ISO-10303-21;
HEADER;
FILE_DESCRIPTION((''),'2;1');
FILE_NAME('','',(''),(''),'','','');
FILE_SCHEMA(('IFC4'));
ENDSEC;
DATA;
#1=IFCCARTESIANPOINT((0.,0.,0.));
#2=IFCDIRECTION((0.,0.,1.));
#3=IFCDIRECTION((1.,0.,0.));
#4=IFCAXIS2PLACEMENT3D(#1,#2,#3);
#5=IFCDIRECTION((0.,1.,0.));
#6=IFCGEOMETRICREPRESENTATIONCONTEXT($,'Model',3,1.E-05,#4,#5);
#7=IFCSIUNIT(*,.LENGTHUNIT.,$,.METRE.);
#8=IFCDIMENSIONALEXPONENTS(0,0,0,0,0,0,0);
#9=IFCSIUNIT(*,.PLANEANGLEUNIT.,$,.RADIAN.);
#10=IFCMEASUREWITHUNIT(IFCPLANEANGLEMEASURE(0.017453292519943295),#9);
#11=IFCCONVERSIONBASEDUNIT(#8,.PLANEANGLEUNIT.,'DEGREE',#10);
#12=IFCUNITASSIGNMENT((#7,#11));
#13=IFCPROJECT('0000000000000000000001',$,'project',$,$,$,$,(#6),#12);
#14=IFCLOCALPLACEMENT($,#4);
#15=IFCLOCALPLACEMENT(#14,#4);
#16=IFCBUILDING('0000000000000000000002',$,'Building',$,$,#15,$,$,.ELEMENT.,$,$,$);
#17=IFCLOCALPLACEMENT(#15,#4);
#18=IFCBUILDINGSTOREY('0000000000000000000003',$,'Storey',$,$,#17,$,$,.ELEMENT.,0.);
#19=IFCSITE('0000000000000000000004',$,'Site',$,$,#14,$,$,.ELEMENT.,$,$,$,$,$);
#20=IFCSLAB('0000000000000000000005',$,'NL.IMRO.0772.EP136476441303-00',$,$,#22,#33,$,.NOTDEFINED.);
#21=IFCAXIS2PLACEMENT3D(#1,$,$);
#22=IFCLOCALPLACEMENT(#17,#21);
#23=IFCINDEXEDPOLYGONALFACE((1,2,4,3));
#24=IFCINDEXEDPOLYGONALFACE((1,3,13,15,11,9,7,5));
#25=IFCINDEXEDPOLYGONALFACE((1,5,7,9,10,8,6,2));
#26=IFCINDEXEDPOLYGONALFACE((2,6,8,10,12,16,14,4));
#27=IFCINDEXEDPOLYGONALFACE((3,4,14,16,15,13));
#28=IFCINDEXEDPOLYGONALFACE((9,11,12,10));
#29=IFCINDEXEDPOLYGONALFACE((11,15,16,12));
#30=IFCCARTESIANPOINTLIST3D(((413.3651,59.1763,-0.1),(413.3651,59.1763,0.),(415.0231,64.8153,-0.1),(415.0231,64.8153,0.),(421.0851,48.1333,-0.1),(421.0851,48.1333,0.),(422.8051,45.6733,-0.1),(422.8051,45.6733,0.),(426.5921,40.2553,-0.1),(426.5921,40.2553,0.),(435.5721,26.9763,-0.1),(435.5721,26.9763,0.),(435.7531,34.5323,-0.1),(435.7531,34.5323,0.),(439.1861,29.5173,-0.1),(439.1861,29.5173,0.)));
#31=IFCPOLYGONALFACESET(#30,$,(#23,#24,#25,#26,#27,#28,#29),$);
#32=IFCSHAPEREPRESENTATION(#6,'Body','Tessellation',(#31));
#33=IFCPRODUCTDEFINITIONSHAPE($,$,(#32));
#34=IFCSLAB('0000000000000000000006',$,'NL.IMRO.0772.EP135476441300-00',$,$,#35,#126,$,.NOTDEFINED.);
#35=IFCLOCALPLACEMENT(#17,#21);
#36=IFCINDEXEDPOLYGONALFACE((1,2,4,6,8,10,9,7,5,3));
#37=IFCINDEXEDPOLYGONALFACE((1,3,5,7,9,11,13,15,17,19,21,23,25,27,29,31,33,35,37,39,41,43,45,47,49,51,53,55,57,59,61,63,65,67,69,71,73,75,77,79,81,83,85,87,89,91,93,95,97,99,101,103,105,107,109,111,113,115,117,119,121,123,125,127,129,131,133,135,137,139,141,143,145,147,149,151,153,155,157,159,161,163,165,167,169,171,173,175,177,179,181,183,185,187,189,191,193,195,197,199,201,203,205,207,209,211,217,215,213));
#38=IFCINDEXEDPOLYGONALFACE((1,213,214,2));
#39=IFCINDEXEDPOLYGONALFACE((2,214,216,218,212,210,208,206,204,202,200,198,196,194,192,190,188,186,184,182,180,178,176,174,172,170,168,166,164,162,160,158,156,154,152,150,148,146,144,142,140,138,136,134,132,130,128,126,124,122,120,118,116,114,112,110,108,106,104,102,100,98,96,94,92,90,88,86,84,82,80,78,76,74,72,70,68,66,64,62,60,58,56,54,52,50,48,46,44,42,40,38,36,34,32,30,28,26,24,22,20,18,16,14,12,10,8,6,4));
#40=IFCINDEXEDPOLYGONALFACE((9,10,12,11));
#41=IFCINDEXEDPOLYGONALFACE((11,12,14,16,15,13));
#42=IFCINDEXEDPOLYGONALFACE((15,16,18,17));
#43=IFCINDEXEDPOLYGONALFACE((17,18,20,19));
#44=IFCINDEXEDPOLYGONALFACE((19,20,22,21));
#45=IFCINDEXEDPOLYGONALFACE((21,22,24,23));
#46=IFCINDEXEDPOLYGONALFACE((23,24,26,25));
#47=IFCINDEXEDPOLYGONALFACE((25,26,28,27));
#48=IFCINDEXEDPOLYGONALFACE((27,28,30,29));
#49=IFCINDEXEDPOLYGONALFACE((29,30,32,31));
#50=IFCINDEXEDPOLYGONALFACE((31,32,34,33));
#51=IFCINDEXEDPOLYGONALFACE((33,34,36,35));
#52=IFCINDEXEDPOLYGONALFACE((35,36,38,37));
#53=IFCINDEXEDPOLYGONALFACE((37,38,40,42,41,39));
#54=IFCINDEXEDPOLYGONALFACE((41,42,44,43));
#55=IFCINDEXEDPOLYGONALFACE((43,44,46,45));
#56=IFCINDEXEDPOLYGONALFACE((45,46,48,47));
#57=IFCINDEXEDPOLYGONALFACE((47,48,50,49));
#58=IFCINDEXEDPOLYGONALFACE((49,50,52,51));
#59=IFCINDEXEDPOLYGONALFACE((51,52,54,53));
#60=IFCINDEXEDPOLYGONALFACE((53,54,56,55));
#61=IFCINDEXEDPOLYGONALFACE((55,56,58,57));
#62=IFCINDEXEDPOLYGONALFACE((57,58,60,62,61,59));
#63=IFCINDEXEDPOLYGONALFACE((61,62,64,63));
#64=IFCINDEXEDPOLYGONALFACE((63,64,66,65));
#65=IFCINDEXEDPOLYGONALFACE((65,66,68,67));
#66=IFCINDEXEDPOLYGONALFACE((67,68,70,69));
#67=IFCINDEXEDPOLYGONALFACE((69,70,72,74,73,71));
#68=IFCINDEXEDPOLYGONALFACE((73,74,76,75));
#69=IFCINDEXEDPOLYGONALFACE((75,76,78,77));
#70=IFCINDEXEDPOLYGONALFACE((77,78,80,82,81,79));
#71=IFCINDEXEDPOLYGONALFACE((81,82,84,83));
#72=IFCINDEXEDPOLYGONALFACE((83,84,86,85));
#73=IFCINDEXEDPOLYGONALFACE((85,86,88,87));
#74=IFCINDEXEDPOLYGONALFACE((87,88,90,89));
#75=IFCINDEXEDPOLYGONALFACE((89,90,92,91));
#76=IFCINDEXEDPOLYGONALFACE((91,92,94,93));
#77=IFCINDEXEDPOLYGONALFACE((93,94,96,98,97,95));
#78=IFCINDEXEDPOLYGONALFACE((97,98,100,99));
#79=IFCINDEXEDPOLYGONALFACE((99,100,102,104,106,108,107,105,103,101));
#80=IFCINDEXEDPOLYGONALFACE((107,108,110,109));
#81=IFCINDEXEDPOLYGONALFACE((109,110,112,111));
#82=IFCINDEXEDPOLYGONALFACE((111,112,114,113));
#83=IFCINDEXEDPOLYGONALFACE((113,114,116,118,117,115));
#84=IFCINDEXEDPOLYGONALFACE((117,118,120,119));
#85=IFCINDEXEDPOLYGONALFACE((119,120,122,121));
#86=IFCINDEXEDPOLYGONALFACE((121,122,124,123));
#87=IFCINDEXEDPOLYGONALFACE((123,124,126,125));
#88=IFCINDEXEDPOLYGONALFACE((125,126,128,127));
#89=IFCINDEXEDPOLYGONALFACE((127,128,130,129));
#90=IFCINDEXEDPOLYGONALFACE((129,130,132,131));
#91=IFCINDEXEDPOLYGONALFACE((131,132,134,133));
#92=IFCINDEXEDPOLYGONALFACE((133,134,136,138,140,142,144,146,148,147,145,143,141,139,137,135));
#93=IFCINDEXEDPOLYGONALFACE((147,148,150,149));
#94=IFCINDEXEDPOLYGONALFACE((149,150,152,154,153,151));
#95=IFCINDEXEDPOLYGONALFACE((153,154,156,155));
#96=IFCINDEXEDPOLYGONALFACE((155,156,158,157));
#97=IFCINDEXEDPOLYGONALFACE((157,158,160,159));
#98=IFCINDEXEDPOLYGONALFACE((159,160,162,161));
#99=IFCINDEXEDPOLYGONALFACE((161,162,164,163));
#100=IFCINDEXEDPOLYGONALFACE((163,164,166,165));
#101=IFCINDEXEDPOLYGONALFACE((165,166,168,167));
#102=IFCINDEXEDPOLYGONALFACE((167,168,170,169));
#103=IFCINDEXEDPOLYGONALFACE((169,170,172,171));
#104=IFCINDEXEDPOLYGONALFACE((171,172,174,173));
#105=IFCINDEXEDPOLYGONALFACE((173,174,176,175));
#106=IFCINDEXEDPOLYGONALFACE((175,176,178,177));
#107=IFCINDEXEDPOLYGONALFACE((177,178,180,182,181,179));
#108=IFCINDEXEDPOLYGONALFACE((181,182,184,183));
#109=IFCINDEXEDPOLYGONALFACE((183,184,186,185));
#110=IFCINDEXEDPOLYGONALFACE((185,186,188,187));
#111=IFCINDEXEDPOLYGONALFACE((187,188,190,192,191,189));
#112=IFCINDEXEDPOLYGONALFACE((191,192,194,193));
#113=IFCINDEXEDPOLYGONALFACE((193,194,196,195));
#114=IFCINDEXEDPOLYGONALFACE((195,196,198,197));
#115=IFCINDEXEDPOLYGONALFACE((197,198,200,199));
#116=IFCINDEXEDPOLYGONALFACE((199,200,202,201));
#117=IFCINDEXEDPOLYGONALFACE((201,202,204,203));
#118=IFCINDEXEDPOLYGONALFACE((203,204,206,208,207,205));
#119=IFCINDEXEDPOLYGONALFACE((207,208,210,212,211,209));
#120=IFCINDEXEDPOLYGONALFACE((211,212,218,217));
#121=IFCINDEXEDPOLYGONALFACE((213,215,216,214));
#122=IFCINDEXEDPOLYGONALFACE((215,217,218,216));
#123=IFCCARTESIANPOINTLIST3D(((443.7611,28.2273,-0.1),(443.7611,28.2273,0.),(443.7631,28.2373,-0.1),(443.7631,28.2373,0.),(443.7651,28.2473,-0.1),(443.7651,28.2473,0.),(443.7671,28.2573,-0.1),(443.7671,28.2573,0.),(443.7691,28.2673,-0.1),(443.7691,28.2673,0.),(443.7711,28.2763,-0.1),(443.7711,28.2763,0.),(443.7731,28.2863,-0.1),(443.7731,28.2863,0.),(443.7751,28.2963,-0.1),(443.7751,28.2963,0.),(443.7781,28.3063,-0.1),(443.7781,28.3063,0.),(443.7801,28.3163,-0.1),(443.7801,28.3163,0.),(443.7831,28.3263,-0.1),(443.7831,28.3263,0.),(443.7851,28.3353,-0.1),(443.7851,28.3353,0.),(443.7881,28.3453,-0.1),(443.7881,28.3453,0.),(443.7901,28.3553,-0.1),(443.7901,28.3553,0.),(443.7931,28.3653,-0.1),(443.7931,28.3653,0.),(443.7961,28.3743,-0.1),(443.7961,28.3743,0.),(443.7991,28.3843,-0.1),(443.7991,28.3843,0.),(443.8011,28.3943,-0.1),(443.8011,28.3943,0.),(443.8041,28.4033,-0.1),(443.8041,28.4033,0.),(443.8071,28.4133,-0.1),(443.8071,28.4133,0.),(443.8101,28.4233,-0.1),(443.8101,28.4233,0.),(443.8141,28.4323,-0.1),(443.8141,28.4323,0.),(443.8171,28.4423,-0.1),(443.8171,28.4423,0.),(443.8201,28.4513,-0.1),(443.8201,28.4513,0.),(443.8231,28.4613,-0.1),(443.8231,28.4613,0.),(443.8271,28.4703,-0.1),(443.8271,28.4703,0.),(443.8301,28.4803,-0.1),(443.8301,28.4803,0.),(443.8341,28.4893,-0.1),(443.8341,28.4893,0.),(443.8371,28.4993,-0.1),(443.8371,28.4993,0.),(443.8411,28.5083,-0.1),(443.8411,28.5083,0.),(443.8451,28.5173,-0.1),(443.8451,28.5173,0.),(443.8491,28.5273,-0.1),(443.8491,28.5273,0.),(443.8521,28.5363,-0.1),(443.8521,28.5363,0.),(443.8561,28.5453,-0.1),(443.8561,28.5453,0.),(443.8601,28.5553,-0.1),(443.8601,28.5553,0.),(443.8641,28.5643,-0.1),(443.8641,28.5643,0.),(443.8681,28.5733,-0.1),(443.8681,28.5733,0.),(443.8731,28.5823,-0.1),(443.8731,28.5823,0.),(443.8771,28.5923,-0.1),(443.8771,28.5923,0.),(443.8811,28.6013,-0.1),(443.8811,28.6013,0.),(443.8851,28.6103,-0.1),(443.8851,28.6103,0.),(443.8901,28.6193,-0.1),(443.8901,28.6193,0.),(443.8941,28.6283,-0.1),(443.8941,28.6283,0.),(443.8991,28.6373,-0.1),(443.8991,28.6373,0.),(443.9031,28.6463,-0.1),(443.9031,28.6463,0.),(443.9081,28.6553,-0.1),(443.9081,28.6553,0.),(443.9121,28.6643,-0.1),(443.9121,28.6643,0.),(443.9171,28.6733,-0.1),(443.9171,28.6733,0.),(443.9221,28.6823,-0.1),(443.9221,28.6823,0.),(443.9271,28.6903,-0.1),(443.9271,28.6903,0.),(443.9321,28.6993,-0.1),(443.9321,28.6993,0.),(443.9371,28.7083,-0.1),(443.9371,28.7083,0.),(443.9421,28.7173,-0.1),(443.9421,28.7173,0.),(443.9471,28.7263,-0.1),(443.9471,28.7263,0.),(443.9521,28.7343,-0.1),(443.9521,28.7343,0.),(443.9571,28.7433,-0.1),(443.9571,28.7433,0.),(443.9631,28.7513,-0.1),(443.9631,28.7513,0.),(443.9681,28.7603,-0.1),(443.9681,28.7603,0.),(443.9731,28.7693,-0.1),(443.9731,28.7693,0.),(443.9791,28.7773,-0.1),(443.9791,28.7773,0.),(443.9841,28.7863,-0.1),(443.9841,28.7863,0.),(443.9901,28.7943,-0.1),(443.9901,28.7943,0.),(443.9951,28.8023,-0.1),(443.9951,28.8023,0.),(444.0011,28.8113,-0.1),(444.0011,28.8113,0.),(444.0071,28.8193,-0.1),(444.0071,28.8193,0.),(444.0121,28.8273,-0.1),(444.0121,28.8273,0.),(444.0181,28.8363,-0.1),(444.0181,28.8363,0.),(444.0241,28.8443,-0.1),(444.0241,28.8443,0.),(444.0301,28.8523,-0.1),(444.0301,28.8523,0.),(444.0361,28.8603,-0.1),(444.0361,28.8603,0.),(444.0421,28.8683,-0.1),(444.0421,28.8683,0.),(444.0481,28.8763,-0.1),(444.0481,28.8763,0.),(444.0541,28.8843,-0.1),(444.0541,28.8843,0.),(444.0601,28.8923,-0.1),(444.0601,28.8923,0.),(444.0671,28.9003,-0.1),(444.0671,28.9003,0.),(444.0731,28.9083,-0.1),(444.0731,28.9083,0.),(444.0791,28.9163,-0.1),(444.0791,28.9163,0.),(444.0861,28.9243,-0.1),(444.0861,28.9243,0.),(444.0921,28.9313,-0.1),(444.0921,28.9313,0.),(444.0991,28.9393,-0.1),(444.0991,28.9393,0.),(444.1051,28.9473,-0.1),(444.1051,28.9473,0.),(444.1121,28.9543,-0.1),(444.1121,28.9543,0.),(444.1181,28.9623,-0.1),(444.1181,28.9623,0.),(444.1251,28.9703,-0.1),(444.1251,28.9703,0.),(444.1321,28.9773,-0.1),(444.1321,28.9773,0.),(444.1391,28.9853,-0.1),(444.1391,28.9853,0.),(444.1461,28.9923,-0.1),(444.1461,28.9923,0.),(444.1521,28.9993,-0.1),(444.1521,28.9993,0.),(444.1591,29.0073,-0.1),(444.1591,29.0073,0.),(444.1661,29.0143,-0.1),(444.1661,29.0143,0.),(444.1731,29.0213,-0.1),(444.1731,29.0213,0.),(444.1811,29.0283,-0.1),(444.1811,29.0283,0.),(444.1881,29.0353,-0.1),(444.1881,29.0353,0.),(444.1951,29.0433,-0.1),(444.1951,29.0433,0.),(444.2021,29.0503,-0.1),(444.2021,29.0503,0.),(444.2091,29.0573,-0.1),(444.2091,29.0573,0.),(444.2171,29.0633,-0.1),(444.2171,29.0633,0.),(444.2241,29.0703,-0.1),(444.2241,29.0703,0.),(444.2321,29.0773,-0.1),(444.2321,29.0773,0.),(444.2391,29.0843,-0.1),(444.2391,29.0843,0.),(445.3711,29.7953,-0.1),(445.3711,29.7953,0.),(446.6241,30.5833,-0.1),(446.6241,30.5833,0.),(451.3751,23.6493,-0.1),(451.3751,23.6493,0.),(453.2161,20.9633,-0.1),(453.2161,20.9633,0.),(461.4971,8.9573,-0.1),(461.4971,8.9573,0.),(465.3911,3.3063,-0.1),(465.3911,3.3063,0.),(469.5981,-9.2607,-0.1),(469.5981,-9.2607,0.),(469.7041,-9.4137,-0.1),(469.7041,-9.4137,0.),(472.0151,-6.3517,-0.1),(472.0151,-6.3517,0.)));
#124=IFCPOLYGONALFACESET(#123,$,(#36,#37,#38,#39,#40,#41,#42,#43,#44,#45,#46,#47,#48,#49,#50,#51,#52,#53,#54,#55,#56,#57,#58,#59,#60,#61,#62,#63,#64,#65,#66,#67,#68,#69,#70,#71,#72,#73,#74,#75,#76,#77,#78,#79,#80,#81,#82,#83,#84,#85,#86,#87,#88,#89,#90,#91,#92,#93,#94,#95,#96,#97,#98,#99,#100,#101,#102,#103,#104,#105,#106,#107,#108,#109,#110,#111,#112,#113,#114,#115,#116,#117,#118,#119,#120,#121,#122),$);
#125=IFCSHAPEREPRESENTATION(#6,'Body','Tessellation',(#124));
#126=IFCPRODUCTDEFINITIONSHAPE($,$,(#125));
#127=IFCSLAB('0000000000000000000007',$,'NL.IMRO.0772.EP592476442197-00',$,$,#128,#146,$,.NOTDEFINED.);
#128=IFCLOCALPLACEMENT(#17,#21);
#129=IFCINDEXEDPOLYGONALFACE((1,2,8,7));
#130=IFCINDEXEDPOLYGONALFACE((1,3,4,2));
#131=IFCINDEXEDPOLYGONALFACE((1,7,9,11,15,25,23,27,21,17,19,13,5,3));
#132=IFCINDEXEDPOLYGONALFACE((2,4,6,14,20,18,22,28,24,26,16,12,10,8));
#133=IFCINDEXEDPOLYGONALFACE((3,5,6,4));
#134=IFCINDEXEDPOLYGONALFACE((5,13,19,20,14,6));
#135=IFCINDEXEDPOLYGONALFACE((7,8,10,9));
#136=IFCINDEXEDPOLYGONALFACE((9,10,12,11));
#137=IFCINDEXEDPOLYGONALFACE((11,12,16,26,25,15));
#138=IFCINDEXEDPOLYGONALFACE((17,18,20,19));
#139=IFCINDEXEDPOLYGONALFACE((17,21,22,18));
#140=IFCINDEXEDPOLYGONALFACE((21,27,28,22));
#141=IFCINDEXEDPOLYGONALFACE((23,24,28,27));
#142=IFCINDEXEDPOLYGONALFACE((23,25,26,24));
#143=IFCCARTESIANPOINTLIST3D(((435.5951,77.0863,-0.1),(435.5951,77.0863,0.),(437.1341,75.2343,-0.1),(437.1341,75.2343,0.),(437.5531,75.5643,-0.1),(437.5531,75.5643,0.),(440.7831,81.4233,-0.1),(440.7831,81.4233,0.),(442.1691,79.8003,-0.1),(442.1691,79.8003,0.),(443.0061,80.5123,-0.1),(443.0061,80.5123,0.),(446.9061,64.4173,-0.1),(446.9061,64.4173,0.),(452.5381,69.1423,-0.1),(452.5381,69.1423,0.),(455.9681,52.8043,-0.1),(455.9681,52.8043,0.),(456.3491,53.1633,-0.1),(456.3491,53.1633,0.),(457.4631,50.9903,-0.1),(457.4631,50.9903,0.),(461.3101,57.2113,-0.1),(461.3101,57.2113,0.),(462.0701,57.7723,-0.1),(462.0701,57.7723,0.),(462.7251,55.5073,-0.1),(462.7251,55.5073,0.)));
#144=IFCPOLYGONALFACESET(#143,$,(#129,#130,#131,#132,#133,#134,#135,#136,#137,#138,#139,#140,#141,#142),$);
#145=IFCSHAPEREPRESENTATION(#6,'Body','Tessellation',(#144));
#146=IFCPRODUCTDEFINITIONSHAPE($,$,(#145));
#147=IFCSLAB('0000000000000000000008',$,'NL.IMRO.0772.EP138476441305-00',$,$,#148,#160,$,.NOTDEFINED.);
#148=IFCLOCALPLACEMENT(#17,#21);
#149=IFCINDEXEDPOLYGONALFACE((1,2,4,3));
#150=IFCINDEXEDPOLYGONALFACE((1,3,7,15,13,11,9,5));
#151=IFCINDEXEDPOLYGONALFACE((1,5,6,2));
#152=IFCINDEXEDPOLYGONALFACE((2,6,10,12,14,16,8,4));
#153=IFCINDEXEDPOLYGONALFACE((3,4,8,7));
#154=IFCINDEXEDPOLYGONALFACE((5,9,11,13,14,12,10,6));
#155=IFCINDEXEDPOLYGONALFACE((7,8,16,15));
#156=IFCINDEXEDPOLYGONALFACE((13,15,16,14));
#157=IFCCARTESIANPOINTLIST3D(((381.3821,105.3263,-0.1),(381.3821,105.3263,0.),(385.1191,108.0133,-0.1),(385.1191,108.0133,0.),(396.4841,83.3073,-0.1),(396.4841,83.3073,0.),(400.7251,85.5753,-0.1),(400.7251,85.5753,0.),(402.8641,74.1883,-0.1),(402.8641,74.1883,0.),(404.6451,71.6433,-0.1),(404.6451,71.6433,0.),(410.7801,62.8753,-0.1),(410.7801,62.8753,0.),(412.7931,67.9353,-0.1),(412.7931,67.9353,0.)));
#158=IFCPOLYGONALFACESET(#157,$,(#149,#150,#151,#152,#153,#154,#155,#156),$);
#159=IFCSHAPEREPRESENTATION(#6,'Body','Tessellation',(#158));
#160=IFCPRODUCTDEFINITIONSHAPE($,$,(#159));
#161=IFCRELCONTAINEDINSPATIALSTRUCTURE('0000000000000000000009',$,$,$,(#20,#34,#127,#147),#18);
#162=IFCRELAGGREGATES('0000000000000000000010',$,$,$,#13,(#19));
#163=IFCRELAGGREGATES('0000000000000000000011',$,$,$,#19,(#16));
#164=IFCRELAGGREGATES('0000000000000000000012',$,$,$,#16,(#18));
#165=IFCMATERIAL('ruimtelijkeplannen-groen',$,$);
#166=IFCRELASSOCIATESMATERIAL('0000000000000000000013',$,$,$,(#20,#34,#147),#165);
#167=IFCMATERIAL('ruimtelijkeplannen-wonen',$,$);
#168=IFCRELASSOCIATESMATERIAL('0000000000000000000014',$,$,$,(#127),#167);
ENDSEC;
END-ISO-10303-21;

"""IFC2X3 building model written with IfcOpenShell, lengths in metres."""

from ifc_helpers import new_model, entity, si_unit, converted_unit, direction, frame, origin_with_axes, place, context, project, spatial, polyline, outline, extrude, material, element, save


model = new_model("IFC2X3")

# Units and contexts
model_context = context("Model", 3, precision=1e-05, world=origin_with_axes(), true_north=direction((0.0, 1.0, 0.0)))
ifc_project = project(units=[si_unit("LENGTHUNIT", "METRE"), converted_unit("PLANEANGLEUNIT", "DEGREE", entity("IfcPlaneAngleMeasure", 0.017453292519943295), si_unit("PLANEANGLEUNIT", "RADIAN"), dimensions=[0, 0, 0, 0, 0, 0, 0])], contexts=[model_context])

# Site, building, storey
site_placement = place(None, origin_with_axes())
site = spatial("IfcSite", under=ifc_project, at=site_placement, Name="Site", CompositionType="ELEMENT")
building_placement = place(site_placement, origin_with_axes())
building = spatial("IfcBuilding", under=site, at=building_placement, Name="Building", CompositionType="ELEMENT")
storey_placement = place(building_placement, origin_with_axes())
storey = spatial("IfcBuildingStorey", under=building, at=storey_placement, Name="Storey", CompositionType="ELEMENT", Elevation=0.0)

# Slabs
ifc_material_1 = material(Name="ruimtelijkeplannen-wonen")
ifc_material_2 = material(Name="ruimtelijkeplannen-groen")
slab_1_placement = place(storey_placement, frame((0.0, 0.0, -0.1), z_axis=(0.0, 0.0, 1.0), x_axis=(1.0, 0.0, 0.0)))
element("IfcSlab", 1, at=slab_1_placement, inside=storey, material=ifc_material_2, Name="NL.IMRO.0772.EP136476441303-00", PredefinedType="NOTDEFINED", context=model_context, shape_type="SweptSolid", body=[
    extrude(outline(polyline([(435.5721, 26.9763), (426.5921, 40.2553), (422.8051, 45.6733), (421.0851, 48.1333), (413.3651, 59.1763), (415.0231, 64.8153), (435.7531, 34.5323), (439.1861, 29.5173), (435.5721, 26.9763)])), origin_with_axes(), (0.0, 0.0, 1.0), 0.1),
])
slab_2_placement = place(storey_placement, frame((0.0, 0.0, -0.1), z_axis=(0.0, 0.0, 1.0), x_axis=(1.0, 0.0, 0.0)))
element("IfcSlab", 2, at=slab_2_placement, inside=storey, material=ifc_material_2, Name="NL.IMRO.0772.EP135476441300-00", PredefinedType="NOTDEFINED", context=model_context, shape_type="SweptSolid", body=[
    extrude(outline(polyline([(445.3711, 29.7953), (446.6241, 30.5833), (451.3751, 23.6493), (453.2161, 20.9633), (461.4971, 8.9573), (465.3911, 3.3063), (472.0151, -6.3517), (469.7041, -9.4137), (469.5981, -9.2607), (443.7611, 28.2273), (443.7631, 28.2373), (443.7651, 28.2473), (443.7671, 28.2573), (443.7691, 28.2673), (443.7711, 28.2763), (443.7731, 28.2863), (443.7751, 28.2963), (443.7781, 28.3063), (443.7801, 28.3163), (443.7831, 28.3263), (443.7851, 28.3353), (443.7881, 28.3453), (443.7901, 28.3553), (443.7931, 28.3653), (443.7961, 28.3743), (443.7991, 28.3843), (443.8011, 28.3943), (443.8041, 28.4033), (443.8071, 28.4133), (443.8101, 28.4233), (443.8141, 28.4323), (443.8171, 28.4423), (443.8201, 28.4513), (443.8231, 28.4613), (443.8271, 28.4703), (443.8301, 28.4803), (443.8341, 28.4893), (443.8371, 28.4993), (443.8411, 28.5083), (443.8451, 28.5173), (443.8491, 28.5273), (443.8521, 28.5363), (443.8561, 28.5453), (443.8601, 28.5553), (443.8641, 28.5643), (443.8681, 28.5733), (443.8731, 28.5823), (443.8771, 28.5923), (443.8811, 28.6013), (443.8851, 28.6103), (443.8901, 28.6193), (443.8941, 28.6283), (443.8991, 28.6373), (443.9031, 28.6463), (443.9081, 28.6553), (443.9121, 28.6643), (443.9171, 28.6733), (443.9221, 28.6823), (443.9271, 28.6903), (443.9321, 28.6993), (443.9371, 28.7083), (443.9421, 28.7173), (443.9471, 28.7263), (443.9521, 28.7343), (443.9571, 28.7433), (443.9631, 28.7513), (443.9681, 28.7603), (443.9731, 28.7693), (443.9791, 28.7773), (443.9841, 28.7863), (443.9901, 28.7943), (443.9951, 28.8023), (444.0011, 28.8113), (444.0071, 28.8193), (444.0121, 28.8273), (444.0181, 28.8363), (444.0241, 28.8443), (444.0301, 28.8523), (444.0361, 28.8603), (444.0421, 28.8683), (444.0481, 28.8763), (444.0541, 28.8843), (444.0601, 28.8923), (444.0671, 28.9003), (444.0731, 28.9083), (444.0791, 28.9163), (444.0861, 28.9243), (444.0921, 28.9313), (444.0991, 28.9393), (444.1051, 28.9473), (444.1121, 28.9543), (444.1181, 28.9623), (444.1251, 28.9703), (444.1321, 28.9773), (444.1391, 28.9853), (444.1461, 28.9923), (444.1521, 28.9993), (444.1591, 29.0073), (444.1661, 29.0143), (444.1731, 29.0213), (444.1811, 29.0283), (444.1881, 29.0353), (444.1951, 29.0433), (444.2021, 29.0503), (444.2091, 29.0573), (444.2171, 29.0633), (444.2241, 29.0703), (444.2321, 29.0773), (444.2391, 29.0843), (445.3711, 29.7953)])), origin_with_axes(), (0.0, 0.0, 1.0), 0.1),
])
slab_3_placement = place(storey_placement, frame((0.0, 0.0, -0.1), z_axis=(0.0, 0.0, 1.0), x_axis=(1.0, 0.0, 0.0)))
element("IfcSlab", 3, at=slab_3_placement, inside=storey, material=ifc_material_1, Name="NL.IMRO.0772.EP592476442197-00", PredefinedType="NOTDEFINED", context=model_context, shape_type="SweptSolid", body=[
    extrude(outline(polyline([(452.5381, 69.1423), (462.0701, 57.7723), (461.3101, 57.2113), (462.7251, 55.5073), (457.4631, 50.9903), (455.9681, 52.8043), (456.3491, 53.1633), (446.9061, 64.4173), (437.5531, 75.5643), (437.1341, 75.2343), (435.5951, 77.0863), (440.7831, 81.4233), (442.1691, 79.8003), (443.0061, 80.5123), (452.5381, 69.1423)])), origin_with_axes(), (0.0, 0.0, 1.0), 0.1),
])
slab_4_placement = place(storey_placement, frame((0.0, 0.0, -0.1), z_axis=(0.0, 0.0, 1.0), x_axis=(1.0, 0.0, 0.0)))
element("IfcSlab", 4, at=slab_4_placement, inside=storey, material=ifc_material_2, Name="NL.IMRO.0772.EP138476441305-00", PredefinedType="NOTDEFINED", context=model_context, shape_type="SweptSolid", body=[
    extrude(outline(polyline([(396.4841, 83.3073), (381.3821, 105.3263), (385.1191, 108.0133), (400.7251, 85.5753), (412.7931, 67.9353), (410.7801, 62.8753), (404.6451, 71.6433), (402.8641, 74.1883), (396.4841, 83.3073)])), origin_with_axes(), (0.0, 0.0, 1.0), 0.1),
])

save(model, "model.ifc")
